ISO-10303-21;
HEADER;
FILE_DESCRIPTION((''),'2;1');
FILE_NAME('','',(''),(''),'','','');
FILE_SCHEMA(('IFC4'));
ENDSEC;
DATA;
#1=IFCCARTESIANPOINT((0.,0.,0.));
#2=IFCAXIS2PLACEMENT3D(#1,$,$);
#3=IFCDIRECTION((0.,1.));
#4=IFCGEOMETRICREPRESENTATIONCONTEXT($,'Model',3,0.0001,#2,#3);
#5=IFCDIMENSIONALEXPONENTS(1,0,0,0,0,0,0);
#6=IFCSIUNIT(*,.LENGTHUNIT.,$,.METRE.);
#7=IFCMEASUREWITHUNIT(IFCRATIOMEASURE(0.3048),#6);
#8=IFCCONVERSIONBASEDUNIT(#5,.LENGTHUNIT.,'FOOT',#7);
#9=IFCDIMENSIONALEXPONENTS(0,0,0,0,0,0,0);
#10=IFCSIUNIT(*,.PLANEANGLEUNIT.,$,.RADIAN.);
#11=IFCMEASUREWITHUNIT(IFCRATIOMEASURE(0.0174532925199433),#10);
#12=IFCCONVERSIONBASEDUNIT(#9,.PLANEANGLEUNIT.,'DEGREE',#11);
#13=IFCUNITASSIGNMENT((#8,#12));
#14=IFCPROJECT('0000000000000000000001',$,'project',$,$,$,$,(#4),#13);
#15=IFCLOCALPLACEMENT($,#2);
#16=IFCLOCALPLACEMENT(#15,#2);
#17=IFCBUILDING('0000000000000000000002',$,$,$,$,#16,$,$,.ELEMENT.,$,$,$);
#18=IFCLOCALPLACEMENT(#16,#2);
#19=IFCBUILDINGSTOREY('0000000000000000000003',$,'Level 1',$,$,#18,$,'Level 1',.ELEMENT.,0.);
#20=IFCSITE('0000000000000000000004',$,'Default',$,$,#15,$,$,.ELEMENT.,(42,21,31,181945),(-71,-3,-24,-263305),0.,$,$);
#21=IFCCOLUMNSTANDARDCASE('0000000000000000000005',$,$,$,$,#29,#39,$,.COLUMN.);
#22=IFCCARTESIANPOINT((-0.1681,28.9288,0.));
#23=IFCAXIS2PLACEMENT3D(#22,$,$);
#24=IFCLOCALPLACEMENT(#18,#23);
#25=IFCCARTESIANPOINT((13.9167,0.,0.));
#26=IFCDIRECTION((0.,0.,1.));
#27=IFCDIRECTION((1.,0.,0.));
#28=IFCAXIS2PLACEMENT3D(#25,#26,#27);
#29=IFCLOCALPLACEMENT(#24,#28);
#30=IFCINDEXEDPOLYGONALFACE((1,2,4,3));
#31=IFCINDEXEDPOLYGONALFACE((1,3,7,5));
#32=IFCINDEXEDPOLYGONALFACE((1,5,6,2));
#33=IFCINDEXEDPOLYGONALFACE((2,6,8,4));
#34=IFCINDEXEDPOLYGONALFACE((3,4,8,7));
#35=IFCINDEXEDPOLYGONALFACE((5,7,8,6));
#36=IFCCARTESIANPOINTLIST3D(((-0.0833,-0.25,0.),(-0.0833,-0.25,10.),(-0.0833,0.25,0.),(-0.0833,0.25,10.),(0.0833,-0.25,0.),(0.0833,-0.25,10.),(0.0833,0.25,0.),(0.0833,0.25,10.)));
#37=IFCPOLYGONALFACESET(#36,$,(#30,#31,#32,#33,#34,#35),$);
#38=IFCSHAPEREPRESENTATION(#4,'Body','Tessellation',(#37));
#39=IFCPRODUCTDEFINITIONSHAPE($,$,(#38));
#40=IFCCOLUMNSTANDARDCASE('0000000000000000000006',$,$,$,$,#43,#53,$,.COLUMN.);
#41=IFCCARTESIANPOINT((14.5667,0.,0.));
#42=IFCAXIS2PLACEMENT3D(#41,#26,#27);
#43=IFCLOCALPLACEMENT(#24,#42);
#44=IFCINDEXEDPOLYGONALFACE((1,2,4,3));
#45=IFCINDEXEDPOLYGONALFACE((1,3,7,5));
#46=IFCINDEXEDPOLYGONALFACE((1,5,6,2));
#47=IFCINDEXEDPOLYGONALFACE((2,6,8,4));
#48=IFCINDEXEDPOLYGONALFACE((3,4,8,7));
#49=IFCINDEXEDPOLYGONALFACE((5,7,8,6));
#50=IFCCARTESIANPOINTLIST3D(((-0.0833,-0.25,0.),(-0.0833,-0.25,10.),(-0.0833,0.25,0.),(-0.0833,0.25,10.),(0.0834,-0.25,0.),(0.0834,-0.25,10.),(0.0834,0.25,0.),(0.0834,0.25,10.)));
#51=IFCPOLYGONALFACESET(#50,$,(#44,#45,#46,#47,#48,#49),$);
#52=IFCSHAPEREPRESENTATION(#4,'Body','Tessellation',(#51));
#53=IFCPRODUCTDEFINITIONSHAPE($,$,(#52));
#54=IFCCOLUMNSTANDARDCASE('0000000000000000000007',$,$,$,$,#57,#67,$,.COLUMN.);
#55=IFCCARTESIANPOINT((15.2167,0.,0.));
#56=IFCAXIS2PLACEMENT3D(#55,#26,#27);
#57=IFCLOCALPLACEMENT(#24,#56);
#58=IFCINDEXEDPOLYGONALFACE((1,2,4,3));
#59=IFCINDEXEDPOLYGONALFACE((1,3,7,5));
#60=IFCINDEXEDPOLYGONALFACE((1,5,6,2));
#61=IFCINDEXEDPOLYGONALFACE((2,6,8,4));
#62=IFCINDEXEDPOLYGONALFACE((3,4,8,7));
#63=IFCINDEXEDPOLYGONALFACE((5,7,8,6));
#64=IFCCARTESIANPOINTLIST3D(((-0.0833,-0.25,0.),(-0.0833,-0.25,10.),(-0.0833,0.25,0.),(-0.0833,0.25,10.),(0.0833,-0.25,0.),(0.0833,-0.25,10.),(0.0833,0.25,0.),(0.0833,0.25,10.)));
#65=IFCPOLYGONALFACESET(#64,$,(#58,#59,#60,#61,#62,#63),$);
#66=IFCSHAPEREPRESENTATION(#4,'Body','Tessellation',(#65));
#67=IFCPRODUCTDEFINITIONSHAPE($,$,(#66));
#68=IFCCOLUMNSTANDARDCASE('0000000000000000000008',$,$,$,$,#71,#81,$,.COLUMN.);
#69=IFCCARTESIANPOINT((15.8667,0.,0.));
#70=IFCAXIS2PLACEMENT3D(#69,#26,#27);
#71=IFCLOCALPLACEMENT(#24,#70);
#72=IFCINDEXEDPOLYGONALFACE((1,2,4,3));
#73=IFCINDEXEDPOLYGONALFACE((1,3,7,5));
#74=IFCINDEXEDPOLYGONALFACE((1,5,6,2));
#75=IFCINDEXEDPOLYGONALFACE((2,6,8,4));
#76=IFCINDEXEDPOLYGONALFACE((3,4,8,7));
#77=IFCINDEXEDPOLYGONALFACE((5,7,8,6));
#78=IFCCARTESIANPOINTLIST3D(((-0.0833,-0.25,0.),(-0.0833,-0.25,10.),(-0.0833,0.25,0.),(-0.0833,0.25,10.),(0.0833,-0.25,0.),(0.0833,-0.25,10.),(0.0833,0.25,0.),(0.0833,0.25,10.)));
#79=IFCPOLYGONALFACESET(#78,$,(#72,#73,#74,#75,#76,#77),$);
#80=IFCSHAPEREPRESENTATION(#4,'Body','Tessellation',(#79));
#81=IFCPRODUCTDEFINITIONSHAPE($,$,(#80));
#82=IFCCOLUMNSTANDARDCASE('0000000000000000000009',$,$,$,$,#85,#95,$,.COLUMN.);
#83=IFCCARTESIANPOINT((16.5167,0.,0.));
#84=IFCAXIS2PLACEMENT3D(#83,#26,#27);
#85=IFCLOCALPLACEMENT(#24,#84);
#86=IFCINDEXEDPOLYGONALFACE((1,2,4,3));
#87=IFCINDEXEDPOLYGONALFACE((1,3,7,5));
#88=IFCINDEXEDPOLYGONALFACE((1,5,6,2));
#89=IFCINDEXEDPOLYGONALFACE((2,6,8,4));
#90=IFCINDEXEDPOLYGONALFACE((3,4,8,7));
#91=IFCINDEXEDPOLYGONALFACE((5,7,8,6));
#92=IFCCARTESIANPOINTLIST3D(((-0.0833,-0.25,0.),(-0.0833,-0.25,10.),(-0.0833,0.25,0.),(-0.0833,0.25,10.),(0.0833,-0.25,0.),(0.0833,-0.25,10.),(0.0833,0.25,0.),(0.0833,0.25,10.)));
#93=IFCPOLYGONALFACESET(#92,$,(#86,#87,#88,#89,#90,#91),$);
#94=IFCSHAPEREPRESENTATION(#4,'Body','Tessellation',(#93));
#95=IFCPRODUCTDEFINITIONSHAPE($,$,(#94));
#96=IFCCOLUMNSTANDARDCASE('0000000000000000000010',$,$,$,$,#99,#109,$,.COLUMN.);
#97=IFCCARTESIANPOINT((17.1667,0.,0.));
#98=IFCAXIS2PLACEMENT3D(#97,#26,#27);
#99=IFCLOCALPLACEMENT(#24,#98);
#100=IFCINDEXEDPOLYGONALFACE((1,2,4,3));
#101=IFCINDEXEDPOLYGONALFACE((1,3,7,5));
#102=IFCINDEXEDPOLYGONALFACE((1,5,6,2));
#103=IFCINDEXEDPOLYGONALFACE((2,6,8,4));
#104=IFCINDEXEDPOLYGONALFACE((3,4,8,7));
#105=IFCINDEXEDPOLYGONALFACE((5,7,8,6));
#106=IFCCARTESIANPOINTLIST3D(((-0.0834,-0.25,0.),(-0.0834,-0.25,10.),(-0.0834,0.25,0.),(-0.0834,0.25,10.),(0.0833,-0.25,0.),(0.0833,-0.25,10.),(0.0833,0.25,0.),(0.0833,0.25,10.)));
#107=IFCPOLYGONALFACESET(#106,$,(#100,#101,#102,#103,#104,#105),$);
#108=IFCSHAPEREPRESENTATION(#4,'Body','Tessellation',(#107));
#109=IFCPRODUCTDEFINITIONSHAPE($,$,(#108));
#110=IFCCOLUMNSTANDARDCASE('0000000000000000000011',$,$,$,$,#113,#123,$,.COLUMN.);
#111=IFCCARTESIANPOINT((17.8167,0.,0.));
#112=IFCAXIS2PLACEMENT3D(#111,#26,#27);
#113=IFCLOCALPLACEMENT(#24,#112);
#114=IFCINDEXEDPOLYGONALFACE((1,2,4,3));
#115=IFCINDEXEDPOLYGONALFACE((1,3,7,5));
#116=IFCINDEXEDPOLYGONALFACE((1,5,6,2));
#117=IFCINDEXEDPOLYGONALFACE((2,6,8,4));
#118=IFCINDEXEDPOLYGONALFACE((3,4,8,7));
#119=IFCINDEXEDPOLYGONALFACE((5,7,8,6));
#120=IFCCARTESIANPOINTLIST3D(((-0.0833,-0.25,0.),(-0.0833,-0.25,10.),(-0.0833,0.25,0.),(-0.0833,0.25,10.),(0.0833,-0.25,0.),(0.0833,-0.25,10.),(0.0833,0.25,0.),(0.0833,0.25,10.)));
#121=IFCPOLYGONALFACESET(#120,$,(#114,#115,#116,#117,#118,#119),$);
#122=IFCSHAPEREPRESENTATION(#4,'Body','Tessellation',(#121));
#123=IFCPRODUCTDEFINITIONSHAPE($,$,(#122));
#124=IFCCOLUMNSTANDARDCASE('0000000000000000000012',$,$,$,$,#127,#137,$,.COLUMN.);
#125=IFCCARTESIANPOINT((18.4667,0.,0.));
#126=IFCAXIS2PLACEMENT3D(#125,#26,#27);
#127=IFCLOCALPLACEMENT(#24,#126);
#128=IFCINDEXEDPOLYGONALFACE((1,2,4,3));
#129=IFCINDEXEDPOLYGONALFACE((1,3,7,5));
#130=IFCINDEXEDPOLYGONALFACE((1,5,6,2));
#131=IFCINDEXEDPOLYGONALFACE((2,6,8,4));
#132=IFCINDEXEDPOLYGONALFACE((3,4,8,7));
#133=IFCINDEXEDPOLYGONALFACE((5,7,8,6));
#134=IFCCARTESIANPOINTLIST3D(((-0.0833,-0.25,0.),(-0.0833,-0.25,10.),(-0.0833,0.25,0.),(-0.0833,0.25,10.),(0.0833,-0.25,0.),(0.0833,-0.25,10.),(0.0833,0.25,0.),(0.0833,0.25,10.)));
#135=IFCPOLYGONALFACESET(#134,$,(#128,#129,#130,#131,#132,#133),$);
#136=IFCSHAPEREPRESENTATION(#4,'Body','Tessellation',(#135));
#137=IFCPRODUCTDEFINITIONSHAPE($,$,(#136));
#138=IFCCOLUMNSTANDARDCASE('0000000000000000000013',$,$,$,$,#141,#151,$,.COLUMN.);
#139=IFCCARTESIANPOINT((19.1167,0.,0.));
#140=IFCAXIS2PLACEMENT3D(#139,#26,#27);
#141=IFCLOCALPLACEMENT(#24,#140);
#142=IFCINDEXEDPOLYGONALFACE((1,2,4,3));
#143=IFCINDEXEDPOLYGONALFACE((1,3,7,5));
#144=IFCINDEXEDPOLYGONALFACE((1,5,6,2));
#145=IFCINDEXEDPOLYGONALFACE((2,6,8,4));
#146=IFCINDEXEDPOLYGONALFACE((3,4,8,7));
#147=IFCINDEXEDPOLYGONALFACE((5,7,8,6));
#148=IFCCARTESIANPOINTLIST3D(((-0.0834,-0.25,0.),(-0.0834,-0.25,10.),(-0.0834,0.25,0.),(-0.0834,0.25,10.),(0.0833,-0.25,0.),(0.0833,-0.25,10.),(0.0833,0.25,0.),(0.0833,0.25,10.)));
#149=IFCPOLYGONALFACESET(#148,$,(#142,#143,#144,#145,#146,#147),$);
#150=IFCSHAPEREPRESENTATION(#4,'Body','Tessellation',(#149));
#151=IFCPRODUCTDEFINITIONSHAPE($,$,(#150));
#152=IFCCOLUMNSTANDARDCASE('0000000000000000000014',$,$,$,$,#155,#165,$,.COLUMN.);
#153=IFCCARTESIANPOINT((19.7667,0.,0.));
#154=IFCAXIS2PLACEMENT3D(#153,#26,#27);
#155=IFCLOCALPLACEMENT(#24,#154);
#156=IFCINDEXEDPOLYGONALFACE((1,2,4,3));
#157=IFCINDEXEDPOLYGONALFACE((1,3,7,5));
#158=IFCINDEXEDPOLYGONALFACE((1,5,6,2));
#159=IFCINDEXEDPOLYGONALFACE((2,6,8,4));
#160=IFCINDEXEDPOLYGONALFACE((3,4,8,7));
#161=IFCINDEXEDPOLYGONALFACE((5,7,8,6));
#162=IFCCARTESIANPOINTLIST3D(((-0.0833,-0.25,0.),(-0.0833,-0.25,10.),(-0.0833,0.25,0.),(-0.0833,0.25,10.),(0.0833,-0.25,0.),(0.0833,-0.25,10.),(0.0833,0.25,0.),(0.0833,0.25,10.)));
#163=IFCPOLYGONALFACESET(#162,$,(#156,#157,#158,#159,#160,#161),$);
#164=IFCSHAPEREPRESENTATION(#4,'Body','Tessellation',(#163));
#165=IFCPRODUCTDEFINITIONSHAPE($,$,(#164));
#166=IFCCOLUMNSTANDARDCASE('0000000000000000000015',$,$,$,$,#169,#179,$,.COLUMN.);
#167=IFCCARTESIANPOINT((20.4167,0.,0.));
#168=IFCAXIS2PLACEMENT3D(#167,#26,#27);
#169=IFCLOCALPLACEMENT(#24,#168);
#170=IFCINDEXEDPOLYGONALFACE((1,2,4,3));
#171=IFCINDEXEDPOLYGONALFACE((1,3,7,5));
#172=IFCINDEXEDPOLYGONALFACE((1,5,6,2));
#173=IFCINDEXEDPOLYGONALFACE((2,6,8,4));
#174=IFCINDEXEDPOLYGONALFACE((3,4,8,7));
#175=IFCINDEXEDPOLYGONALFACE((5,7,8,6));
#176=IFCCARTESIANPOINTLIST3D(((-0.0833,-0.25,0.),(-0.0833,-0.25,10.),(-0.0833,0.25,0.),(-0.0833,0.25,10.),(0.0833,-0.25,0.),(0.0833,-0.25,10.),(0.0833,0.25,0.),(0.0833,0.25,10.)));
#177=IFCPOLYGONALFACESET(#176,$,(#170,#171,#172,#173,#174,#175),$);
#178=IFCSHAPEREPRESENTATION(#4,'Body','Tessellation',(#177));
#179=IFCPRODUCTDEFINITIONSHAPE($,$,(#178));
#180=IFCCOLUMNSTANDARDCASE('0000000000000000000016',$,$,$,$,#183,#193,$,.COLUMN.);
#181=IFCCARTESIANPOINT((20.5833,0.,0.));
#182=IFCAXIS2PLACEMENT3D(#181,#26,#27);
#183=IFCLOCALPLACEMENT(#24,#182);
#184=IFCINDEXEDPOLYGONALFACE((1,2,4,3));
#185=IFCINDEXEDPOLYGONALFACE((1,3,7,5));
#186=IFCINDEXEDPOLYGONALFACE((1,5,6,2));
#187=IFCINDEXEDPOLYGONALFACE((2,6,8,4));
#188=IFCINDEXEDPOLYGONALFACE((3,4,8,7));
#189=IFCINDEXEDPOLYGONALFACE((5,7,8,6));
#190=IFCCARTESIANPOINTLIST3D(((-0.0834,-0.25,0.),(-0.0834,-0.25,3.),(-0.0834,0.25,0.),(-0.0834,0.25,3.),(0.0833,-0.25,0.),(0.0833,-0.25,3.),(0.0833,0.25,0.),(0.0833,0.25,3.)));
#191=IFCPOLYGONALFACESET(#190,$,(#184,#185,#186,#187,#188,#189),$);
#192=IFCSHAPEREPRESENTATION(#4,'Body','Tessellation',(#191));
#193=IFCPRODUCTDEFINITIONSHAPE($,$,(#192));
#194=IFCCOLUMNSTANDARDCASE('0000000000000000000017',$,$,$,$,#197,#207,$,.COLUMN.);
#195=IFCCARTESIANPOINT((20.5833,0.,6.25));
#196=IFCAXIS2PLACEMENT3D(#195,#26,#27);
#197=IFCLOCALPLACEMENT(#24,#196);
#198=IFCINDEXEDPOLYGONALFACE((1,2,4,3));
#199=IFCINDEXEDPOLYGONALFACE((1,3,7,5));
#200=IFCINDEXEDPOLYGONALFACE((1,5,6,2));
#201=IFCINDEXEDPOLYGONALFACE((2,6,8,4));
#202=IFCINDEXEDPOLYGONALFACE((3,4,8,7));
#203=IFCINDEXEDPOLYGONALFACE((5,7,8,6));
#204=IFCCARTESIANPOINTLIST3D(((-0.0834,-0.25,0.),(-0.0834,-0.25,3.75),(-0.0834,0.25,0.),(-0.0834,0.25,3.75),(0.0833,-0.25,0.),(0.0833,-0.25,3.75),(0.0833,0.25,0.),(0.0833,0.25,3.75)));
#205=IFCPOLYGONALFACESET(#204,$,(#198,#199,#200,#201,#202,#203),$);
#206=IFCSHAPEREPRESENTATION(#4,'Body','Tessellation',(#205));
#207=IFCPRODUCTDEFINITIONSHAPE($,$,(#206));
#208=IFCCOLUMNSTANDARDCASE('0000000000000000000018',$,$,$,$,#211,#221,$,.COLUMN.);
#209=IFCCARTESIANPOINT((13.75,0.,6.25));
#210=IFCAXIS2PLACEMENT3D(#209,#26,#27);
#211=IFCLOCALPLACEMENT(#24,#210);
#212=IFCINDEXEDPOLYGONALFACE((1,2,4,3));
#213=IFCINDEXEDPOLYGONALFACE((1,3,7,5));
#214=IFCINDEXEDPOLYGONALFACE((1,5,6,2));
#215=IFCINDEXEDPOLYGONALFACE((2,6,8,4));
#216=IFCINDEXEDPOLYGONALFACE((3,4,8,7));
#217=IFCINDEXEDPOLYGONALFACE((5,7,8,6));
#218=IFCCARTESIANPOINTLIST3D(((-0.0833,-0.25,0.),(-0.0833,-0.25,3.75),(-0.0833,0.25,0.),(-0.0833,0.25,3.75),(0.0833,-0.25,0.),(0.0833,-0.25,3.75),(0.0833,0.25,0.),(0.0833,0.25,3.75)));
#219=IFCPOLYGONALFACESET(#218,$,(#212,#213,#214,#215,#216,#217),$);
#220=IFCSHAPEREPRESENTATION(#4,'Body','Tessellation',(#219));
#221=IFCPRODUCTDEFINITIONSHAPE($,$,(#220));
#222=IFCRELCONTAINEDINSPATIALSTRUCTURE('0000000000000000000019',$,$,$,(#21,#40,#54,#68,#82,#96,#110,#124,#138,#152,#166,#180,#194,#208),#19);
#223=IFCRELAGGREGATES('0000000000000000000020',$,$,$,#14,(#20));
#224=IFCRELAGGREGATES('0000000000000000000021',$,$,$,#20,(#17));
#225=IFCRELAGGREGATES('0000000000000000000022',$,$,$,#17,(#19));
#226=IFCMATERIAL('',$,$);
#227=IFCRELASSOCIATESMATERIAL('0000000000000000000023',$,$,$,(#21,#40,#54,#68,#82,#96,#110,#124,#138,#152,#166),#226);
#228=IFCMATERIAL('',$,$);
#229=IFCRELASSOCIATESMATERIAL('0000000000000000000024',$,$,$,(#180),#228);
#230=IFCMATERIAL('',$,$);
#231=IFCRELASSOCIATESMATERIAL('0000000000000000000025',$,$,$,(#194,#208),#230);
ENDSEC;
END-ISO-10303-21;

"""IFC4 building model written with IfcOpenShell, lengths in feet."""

from ifc_helpers import new_model, entity, si_unit, converted_unit, direction, frame, origin, place, context, project, spatial, rectangle, extrude, material, element, save


model = new_model("IFC4")

# Units and contexts
model_context = context("Model", 3, precision=0.0001, world=origin(), true_north=direction((0.0, 1.0)))
ifc_project = project(units=[converted_unit("LENGTHUNIT", "FOOT", entity("IfcRatioMeasure", 0.3048), si_unit("LENGTHUNIT", "METRE"), dimensions=[1, 0, 0, 0, 0, 0, 0]), converted_unit("PLANEANGLEUNIT", "DEGREE", entity("IfcRatioMeasure", 0.0174532925199433), si_unit("PLANEANGLEUNIT", "RADIAN"), dimensions=[0, 0, 0, 0, 0, 0, 0])], contexts=[model_context])

# Site, building, storey
site_placement = place(None, origin())
site = spatial("IfcSite", under=ifc_project, at=site_placement, Name="Default", CompositionType="ELEMENT", RefLatitude=(42, 21, 31, 181945), RefLongitude=(-71, -3, -24, -263305), RefElevation=0.0)
building_placement = place(site_placement, origin())
building = spatial("IfcBuilding", under=site, at=building_placement, CompositionType="ELEMENT")
storey_placement = place(building_placement, origin())
storey = spatial("IfcBuildingStorey", under=building, at=storey_placement, Name="Level 1", LongName="Level 1", CompositionType="ELEMENT", Elevation=0.0)

# Columns
ifc_material_1 = material(Name="")
placement = place(storey_placement, frame((-0.1681, 28.9288, 0.0)))
for number, where, z_axis, x_axis in (
    (1, (13.9167, 0.0, 0.0), (0.0, 0.0, 1.0), (1.0, 0.0, 0.0)),
    (2, (14.5667, 0.0, 0.0), (0.0, 0.0, 1.0), (1.0, 0.0, 0.0)),
    (3, (15.2167, 0.0, 0.0), (0.0, 0.0, 1.0), (1.0, 0.0, 0.0)),
    (4, (15.8667, 0.0, 0.0), (0.0, 0.0, 1.0), (1.0, 0.0, 0.0)),
    (5, (16.5167, 0.0, 0.0), (0.0, 0.0, 1.0), (1.0, 0.0, 0.0)),
    (6, (17.1667, 0.0, 0.0), (0.0, 0.0, 1.0), (1.0, 0.0, 0.0)),
    (7, (17.8167, 0.0, 0.0), (0.0, 0.0, 1.0), (1.0, 0.0, 0.0)),
    (8, (18.4667, 0.0, 0.0), (0.0, 0.0, 1.0), (1.0, 0.0, 0.0)),
    (9, (19.1167, 0.0, 0.0), (0.0, 0.0, 1.0), (1.0, 0.0, 0.0)),
    (10, (19.7667, 0.0, 0.0), (0.0, 0.0, 1.0), (1.0, 0.0, 0.0)),
    (11, (20.4167, 0.0, 0.0), (0.0, 0.0, 1.0), (1.0, 0.0, 0.0)),
):
    element("IfcColumnStandardCase", number, at=place(placement, frame(where, z_axis=z_axis, x_axis=x_axis)), inside=storey, material=ifc_material_1, PredefinedType="COLUMN", context=model_context, shape_type="SweptSolid", body=[
        extrude(rectangle(XDim=0.1667, YDim=0.5), origin(), (0.0, 0.0, 1.0), 10.0),
    ])
ifc_material_2 = material(Name="")
for number, where, z_axis, x_axis in (
    (12, (20.5833, 0.0, 0.0), (0.0, 0.0, 1.0), (1.0, 0.0, 0.0)),
):
    element("IfcColumnStandardCase", number, at=place(placement, frame(where, z_axis=z_axis, x_axis=x_axis)), inside=storey, material=ifc_material_2, PredefinedType="COLUMN", context=model_context, shape_type="SweptSolid", body=[
        extrude(rectangle(XDim=0.1667, YDim=0.5), origin(), (0.0, 0.0, 1.0), 3.0),
    ])
ifc_material_3 = material(Name="")
for number, where, z_axis, x_axis in (
    (13, (20.5833, 0.0, 6.25), (0.0, 0.0, 1.0), (1.0, 0.0, 0.0)),
    (14, (13.75, 0.0, 6.25), (0.0, 0.0, 1.0), (1.0, 0.0, 0.0)),
):
    element("IfcColumnStandardCase", number, at=place(placement, frame(where, z_axis=z_axis, x_axis=x_axis)), inside=storey, material=ifc_material_3, PredefinedType="COLUMN", context=model_context, shape_type="SweptSolid", body=[
        extrude(rectangle(XDim=0.1667, YDim=0.5), origin(), (0.0, 0.0, 1.0), 3.75),
    ])

save(model, "model.ifc")
